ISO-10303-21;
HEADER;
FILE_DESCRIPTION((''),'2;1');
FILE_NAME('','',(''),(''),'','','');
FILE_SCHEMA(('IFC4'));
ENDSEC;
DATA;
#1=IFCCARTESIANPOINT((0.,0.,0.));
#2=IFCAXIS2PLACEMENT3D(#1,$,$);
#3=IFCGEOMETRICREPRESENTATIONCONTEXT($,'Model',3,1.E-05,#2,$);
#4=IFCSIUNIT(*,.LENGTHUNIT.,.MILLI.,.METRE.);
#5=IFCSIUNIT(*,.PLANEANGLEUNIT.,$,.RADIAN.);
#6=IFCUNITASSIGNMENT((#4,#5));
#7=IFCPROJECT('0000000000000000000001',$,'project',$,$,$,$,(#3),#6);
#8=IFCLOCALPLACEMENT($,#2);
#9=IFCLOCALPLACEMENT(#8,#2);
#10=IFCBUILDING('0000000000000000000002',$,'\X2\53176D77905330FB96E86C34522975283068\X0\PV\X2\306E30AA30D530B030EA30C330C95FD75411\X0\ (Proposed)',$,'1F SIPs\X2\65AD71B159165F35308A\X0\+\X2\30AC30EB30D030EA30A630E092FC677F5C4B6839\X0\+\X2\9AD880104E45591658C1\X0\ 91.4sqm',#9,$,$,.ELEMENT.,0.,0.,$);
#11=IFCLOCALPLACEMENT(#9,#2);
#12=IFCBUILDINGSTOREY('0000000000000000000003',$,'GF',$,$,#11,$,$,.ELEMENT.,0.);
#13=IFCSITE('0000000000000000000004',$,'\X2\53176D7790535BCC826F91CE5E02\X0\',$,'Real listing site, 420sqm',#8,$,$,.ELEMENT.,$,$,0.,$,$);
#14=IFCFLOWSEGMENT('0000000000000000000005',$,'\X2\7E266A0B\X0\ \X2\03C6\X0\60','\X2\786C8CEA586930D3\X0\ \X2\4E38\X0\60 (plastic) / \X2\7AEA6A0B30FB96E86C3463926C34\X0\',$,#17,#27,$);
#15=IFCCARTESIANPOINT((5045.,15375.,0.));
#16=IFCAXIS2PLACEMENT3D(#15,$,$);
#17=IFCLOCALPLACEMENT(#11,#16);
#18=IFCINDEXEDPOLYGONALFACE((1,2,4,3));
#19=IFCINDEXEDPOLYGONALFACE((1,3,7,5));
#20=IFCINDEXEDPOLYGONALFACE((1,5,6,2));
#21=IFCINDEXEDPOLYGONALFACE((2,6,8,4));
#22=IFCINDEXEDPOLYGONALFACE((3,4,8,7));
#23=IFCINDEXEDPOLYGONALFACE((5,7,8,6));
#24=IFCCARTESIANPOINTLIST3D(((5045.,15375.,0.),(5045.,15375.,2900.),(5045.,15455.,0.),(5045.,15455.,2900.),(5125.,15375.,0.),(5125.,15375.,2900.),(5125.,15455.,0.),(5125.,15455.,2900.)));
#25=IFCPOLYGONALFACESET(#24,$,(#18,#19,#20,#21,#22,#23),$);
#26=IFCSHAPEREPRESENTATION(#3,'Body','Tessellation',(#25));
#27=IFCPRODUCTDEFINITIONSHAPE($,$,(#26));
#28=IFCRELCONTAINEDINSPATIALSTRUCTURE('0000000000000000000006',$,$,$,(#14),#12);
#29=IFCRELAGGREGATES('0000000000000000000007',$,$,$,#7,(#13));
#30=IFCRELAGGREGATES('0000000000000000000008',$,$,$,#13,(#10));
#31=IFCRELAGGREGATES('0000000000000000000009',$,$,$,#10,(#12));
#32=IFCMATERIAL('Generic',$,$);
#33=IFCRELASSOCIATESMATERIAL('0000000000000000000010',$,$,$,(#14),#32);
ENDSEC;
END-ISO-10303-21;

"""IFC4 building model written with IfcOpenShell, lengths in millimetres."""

from ifc_helpers import new_model, si_unit, frame, frame_2d, origin, place, context, project, spatial, rectangle, extrude, material, element, save


model = new_model("IFC4")

# Units and contexts
model_context = context("Model", 3, precision=1e-05, world=origin())
ifc_project = project(units=[si_unit("LENGTHUNIT", "METRE", prefix="MILLI"), si_unit("PLANEANGLEUNIT", "RADIAN")], contexts=[model_context])

# Site, building, storey
site_placement = place(None, origin())
site = spatial("IfcSite", under=ifc_project, at=site_placement, Name="北海道富良野市", ObjectType="Real listing site, 420sqm", CompositionType="ELEMENT", RefElevation=0.0)
building_placement = place(site_placement, origin())
building = spatial("IfcBuilding", under=site, at=building_placement, Name="北海道・雨水利用とPVのオフグリッド志向 (Proposed)", ObjectType="1F SIPs断熱外張り+ガルバリウム鋼板屋根+高耐久外壁 91.4sqm", CompositionType="ELEMENT", ElevationOfRefHeight=0.0, ElevationOfTerrain=0.0)
storey_placement = place(building_placement, origin())
storey = spatial("IfcBuildingStorey", under=building, at=storey_placement, Name="GF", CompositionType="ELEMENT", Elevation=0.0)

# Shared definitions
ifc_material_1 = material(Name="Generic")

# Flow segment
flow_segment_1_placement = place(storey_placement, frame((5045.0, 15375.0, 0.0)))
element("IfcFlowSegment", 1, at=flow_segment_1_placement, inside=storey, material=ifc_material_1, Name="縦樋 φ60", Description="硬質塩ビ 丸60 (plastic) / 竪樋・雨水排水", context=model_context, shape_type="SweptSolid", body=[
    extrude(rectangle(XDim=80.0, YDim=80.0, at=frame_2d((40.0, 40.0))), frame((5045.0, 15375.0, 0.0)), (0.0, 0.0, 1.0), 2900.0),
])

save(model, "model.ifc")
